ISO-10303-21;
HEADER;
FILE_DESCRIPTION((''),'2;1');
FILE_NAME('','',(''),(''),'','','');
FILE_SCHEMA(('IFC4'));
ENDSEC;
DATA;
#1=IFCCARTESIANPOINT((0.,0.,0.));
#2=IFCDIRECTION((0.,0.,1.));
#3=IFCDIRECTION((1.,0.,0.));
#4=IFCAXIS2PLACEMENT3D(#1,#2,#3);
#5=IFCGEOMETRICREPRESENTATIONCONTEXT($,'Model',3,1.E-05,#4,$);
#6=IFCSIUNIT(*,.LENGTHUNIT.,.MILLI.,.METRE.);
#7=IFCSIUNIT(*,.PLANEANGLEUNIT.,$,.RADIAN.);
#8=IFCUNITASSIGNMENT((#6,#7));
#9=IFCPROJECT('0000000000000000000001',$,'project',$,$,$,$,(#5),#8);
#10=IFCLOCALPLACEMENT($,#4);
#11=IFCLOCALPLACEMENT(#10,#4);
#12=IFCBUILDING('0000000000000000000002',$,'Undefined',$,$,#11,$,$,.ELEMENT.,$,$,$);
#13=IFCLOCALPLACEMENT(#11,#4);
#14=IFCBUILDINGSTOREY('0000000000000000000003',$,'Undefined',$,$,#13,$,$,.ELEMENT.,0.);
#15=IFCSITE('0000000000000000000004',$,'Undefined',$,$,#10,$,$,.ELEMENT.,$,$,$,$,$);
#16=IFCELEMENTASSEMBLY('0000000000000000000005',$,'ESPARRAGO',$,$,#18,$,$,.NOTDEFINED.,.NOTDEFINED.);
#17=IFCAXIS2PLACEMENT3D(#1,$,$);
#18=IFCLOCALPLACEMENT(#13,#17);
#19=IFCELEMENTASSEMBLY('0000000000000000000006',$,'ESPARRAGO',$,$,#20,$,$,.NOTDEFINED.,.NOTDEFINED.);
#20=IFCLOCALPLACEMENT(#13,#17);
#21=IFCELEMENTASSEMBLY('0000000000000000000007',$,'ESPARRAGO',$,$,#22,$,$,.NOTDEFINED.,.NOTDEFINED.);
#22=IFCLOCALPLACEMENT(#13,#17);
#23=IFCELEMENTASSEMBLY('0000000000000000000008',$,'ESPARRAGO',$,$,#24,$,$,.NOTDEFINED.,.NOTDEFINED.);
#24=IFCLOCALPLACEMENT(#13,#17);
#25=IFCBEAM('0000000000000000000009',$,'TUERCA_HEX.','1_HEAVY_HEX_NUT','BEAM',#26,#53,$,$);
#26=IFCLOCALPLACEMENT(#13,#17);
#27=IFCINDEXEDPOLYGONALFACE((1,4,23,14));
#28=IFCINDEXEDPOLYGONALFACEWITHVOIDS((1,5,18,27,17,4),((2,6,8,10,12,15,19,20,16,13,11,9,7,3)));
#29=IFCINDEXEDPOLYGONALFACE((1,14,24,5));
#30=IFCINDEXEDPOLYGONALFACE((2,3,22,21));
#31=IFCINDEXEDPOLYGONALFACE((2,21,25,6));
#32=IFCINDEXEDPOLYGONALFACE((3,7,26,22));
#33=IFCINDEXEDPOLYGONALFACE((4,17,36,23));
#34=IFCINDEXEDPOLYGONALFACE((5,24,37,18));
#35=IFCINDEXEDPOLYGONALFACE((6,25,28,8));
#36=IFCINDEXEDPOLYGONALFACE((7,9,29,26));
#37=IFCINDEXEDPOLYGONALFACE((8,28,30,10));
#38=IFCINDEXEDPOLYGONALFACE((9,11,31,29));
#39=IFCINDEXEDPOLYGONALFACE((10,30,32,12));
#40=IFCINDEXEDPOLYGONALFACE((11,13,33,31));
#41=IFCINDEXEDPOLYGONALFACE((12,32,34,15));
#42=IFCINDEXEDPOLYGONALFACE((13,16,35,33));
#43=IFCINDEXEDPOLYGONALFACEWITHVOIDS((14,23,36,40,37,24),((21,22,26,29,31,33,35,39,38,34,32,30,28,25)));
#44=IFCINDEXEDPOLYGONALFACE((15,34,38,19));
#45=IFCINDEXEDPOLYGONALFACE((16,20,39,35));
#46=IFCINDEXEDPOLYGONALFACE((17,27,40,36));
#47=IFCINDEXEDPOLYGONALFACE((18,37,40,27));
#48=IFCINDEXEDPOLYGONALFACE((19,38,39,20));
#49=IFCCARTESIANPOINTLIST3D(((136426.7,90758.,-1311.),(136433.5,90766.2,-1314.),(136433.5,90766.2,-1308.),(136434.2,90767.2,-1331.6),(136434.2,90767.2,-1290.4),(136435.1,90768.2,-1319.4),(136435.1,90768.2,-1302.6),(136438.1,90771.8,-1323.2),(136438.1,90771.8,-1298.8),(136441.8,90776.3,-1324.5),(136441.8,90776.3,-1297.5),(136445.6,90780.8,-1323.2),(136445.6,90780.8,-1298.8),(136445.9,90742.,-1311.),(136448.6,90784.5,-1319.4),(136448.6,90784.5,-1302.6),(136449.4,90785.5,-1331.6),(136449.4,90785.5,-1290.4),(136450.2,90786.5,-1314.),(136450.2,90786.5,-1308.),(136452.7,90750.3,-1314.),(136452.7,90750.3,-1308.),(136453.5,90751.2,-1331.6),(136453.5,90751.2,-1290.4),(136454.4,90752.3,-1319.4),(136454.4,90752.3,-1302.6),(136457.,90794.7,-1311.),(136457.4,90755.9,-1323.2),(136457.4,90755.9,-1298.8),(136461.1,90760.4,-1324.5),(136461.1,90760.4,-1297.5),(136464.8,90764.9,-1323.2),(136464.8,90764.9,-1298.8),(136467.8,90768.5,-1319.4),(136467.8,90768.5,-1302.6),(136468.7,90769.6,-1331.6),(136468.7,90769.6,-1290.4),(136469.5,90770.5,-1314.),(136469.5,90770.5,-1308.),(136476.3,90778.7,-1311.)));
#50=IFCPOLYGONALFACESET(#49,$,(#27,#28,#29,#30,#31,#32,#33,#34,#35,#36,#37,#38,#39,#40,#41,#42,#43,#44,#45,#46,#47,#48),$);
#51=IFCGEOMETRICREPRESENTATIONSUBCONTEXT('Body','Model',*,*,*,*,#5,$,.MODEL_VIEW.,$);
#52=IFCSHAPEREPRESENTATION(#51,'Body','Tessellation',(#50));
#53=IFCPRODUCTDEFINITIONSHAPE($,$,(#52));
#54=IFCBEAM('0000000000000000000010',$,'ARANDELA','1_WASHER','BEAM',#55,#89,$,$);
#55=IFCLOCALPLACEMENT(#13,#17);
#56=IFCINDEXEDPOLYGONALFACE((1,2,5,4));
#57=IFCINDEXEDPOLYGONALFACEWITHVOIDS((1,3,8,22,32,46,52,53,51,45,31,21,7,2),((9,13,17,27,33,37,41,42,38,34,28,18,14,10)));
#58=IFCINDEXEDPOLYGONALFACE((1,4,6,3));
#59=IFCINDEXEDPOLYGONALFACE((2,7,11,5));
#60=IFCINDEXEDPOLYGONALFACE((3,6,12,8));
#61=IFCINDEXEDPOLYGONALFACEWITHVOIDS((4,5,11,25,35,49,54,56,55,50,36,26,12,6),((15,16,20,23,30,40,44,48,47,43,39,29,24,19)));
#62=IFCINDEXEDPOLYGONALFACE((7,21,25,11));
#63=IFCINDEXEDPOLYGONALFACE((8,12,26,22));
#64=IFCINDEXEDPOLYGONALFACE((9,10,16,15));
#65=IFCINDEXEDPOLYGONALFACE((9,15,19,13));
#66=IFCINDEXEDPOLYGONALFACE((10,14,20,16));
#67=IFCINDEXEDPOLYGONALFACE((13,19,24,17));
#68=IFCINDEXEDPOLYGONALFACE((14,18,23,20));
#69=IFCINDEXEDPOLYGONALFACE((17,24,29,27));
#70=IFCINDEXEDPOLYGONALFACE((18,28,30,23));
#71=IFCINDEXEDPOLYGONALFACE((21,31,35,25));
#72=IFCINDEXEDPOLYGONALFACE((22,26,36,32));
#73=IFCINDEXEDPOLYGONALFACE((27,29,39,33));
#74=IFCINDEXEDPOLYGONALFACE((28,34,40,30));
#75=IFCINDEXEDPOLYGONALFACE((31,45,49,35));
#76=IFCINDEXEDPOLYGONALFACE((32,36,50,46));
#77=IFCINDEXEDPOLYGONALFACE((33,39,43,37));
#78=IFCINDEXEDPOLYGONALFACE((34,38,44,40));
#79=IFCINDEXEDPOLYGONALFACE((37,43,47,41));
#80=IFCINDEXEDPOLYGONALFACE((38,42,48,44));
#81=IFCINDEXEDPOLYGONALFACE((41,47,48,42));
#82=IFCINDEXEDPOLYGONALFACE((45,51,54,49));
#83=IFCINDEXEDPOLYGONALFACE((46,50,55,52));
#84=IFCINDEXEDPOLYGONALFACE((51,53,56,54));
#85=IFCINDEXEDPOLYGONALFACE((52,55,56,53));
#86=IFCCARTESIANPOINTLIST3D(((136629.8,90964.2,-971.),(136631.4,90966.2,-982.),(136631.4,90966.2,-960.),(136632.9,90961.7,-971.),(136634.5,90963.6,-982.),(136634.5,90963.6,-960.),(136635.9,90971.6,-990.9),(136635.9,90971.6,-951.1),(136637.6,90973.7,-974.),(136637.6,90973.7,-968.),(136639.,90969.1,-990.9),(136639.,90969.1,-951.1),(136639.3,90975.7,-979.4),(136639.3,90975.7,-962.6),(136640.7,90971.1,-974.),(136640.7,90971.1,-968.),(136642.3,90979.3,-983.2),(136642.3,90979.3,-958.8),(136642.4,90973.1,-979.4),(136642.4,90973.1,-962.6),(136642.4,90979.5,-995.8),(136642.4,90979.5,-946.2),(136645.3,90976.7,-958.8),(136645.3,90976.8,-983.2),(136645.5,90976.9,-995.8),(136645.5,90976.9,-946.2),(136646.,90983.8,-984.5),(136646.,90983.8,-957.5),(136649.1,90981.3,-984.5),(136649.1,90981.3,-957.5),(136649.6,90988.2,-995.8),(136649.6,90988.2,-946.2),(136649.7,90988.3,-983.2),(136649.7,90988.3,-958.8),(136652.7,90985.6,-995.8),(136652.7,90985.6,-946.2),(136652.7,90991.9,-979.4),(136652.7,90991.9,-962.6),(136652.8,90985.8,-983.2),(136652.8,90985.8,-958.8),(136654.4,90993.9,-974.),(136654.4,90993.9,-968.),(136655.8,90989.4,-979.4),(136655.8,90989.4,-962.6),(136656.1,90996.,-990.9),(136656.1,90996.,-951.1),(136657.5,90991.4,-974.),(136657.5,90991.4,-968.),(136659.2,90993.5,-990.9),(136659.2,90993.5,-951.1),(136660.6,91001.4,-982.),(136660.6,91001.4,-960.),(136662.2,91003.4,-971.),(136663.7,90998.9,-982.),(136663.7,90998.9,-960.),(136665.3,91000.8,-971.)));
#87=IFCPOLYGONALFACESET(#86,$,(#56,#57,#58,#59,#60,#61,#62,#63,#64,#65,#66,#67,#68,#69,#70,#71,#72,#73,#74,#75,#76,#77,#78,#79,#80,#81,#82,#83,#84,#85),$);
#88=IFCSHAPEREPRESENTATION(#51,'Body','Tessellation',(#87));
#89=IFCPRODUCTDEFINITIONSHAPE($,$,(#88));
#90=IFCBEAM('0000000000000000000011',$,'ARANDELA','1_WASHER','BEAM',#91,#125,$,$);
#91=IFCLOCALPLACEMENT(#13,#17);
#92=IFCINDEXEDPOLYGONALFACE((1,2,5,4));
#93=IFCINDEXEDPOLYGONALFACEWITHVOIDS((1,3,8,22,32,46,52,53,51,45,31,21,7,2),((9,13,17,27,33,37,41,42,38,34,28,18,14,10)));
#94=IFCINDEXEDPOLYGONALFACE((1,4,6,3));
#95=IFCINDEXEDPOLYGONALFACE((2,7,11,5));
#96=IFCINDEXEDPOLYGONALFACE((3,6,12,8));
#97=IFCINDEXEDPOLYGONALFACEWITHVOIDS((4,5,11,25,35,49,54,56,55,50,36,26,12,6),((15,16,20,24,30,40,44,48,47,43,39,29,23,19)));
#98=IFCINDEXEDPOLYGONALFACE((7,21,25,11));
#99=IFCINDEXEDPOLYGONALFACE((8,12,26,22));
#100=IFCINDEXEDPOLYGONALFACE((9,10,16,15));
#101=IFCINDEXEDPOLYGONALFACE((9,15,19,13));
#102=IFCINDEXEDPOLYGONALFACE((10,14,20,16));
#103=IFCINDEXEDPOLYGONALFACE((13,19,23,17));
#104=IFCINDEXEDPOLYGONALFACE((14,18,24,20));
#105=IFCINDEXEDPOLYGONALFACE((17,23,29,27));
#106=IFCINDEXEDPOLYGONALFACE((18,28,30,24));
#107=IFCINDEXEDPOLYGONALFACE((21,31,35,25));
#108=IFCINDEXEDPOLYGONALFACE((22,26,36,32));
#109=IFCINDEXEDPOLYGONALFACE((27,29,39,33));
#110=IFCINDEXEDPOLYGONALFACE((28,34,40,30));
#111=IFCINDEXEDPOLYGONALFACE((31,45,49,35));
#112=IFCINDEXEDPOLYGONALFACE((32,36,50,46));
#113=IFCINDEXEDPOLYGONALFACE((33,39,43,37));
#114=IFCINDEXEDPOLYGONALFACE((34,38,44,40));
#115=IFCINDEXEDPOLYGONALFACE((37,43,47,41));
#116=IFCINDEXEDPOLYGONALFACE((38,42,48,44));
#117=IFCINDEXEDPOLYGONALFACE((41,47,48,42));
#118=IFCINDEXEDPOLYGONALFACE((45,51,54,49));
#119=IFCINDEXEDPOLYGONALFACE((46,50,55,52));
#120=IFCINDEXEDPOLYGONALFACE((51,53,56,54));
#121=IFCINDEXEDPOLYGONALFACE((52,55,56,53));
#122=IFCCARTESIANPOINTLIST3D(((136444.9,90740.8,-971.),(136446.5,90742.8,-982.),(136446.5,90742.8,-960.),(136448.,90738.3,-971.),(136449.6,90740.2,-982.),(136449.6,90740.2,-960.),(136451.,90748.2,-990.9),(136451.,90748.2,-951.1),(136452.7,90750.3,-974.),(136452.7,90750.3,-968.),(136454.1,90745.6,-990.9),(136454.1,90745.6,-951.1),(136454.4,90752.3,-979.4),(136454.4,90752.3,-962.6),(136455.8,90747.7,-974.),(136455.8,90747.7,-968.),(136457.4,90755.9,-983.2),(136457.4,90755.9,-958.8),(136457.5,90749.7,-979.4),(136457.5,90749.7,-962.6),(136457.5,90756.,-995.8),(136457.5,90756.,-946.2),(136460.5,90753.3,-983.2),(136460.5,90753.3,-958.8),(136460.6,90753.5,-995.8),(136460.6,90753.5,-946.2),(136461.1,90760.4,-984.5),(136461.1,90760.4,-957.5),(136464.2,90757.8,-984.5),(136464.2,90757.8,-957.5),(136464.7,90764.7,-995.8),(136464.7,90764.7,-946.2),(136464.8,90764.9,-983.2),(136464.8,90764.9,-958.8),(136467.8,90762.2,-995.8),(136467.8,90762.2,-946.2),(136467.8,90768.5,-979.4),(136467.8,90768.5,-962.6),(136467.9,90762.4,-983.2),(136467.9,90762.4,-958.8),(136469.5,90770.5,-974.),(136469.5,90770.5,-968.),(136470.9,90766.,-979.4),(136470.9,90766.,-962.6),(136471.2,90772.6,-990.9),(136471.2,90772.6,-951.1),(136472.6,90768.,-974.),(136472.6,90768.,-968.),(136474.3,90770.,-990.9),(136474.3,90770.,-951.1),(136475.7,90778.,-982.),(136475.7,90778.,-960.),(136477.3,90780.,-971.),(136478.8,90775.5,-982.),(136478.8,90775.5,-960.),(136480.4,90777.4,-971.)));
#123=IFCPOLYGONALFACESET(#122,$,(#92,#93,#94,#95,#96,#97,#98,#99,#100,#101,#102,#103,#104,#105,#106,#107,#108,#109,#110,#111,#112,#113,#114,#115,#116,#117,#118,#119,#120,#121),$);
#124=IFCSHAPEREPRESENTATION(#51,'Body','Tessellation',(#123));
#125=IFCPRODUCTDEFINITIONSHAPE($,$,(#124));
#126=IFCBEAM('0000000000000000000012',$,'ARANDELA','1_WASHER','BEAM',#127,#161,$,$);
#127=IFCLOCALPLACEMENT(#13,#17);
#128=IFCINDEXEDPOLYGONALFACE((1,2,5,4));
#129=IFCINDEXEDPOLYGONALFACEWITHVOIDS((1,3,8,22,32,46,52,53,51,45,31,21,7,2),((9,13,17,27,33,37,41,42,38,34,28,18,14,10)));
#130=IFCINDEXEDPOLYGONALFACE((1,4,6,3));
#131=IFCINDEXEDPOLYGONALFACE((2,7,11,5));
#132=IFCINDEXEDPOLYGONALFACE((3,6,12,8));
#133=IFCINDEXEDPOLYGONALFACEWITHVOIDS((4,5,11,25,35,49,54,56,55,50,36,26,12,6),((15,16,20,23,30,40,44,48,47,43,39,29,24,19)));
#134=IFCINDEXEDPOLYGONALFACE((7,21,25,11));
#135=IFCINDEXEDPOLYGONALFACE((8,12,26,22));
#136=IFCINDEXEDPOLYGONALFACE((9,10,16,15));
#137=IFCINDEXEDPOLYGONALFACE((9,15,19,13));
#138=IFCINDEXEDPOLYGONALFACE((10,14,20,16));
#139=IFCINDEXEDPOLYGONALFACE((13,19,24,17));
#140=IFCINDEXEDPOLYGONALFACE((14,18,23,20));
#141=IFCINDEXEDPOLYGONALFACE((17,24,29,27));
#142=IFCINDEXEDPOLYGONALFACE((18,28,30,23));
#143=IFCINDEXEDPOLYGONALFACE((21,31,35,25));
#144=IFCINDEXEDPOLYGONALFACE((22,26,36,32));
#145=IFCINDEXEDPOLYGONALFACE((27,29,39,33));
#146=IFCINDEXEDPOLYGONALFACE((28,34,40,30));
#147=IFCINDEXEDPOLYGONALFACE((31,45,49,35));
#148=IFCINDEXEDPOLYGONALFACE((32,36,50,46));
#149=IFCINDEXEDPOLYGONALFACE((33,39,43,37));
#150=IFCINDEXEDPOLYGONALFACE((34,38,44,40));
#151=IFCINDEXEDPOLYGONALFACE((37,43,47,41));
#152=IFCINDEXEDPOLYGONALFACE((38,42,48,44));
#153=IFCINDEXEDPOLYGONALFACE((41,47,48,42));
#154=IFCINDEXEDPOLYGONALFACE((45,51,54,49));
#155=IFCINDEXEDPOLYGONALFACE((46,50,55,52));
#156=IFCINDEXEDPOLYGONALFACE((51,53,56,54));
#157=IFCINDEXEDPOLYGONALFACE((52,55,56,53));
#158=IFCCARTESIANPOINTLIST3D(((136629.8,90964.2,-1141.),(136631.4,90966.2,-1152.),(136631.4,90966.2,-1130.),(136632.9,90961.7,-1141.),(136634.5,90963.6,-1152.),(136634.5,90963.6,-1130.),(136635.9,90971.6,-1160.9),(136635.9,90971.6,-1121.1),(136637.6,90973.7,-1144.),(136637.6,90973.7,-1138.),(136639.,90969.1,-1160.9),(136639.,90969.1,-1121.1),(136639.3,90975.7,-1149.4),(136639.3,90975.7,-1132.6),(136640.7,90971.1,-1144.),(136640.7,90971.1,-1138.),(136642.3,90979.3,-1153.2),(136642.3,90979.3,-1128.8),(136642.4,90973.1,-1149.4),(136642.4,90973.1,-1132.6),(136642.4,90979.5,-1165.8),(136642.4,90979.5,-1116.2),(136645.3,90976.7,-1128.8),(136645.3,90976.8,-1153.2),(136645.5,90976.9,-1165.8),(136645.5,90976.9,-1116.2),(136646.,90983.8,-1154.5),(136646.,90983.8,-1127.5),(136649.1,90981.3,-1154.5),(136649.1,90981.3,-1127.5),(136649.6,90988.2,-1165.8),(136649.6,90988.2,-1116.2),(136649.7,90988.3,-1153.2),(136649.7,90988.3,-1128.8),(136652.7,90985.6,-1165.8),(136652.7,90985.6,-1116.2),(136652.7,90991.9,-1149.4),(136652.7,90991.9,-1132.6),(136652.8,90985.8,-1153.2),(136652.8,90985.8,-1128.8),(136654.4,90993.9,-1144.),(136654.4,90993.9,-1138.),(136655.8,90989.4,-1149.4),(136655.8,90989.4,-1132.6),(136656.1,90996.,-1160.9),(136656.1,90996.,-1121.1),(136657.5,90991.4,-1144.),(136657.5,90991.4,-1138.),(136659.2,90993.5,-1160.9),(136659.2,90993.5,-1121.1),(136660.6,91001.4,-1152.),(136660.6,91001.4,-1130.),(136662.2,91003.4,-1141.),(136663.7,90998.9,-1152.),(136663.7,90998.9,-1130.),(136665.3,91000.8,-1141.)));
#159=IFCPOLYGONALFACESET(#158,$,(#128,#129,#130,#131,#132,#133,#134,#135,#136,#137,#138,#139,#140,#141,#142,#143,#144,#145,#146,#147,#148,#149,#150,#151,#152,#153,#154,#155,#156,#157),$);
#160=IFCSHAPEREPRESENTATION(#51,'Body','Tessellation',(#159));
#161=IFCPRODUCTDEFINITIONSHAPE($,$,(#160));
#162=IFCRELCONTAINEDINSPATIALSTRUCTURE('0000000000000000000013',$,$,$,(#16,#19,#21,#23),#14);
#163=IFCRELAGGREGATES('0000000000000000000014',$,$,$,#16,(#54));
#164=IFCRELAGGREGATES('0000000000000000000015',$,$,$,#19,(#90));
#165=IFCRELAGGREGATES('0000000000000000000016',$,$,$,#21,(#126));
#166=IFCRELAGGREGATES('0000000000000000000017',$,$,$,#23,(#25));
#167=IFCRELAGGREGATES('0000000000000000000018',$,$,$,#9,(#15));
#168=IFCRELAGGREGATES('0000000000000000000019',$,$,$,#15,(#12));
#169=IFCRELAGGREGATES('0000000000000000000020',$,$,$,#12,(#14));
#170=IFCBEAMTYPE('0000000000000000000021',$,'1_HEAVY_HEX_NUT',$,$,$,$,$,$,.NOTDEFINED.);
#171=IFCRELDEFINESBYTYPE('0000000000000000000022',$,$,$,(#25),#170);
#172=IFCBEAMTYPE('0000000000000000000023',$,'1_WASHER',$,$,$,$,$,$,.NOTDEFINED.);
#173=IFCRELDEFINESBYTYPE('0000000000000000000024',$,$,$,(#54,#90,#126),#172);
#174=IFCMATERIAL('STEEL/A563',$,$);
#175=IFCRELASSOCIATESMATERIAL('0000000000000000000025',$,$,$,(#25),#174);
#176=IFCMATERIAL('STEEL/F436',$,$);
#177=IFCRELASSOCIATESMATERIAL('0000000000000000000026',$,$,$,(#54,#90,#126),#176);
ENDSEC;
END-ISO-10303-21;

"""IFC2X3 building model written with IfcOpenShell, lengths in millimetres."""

from ifc_helpers import new_model, si_unit, frame, origin_with_axes, place, context, subcontext, project, spatial, polyline, outline, extrude, material, type_object, element, aggregate, save


model = new_model("IFC2X3")

# Units and contexts
model_context = context("Model", 3, precision=1e-05, world=origin_with_axes())
body_context = subcontext(model_context, "Body", "Model", "MODEL_VIEW")
ifc_project = project(units=[si_unit("LENGTHUNIT", "METRE", prefix="MILLI"), si_unit("PLANEANGLEUNIT", "RADIAN")], contexts=[model_context])

# Site, building, storey
site_placement = place(None, origin_with_axes())
site = spatial("IfcSite", under=ifc_project, at=site_placement, Name="Undefined", CompositionType="ELEMENT")
building_placement = place(site_placement, origin_with_axes())
building = spatial("IfcBuilding", under=site, at=building_placement, Name="Undefined", CompositionType="ELEMENT")
storey_placement = place(building_placement, origin_with_axes())
storey = spatial("IfcBuildingStorey", under=building, at=storey_placement, Name="Undefined", CompositionType="ELEMENT", Elevation=0.0)

# Element assemblies, beam
assembly_1_placement = place(storey_placement, origin_with_axes())
assembly_1 = element("IfcElementAssembly", 1, at=assembly_1_placement, inside=storey, Name="ESPARRAGO", AssemblyPlace="NOTDEFINED", PredefinedType="NOTDEFINED")
ifc_material_1 = material(Name="STEEL/A563")
beam_type_1 = type_object("IfcBeamType", Name="1_HEAVY_HEX_NUT", PredefinedType="NOTDEFINED")
assembly_2_placement = place(storey_placement, origin_with_axes())
assembly_2 = element("IfcElementAssembly", 2, at=assembly_2_placement, inside=storey, Name="ESPARRAGO", AssemblyPlace="NOTDEFINED", PredefinedType="NOTDEFINED")
assembly_3_placement = place(storey_placement, origin_with_axes())
assembly_3 = element("IfcElementAssembly", 3, at=assembly_3_placement, inside=storey, Name="ESPARRAGO", AssemblyPlace="NOTDEFINED", PredefinedType="NOTDEFINED")
assembly_4_placement = place(storey_placement, origin_with_axes())
assembly_4 = element("IfcElementAssembly", 4, at=assembly_4_placement, inside=storey, Name="ESPARRAGO", AssemblyPlace="NOTDEFINED", PredefinedType="NOTDEFINED")
beam_1_placement = place(assembly_4_placement, frame((136441.8, 90776.3, -1311.0), z_axis=(0.000011, -0.000009, 1.0), x_axis=(0.770401, -0.63756, -0.000014)))
beam_1 = element("IfcBeam", 5, at=beam_1_placement, type_object=beam_type_1, material=ifc_material_1, Name="TUERCA_HEX.", Description="1_HEAVY_HEX_NUT", ObjectType="BEAM", context=body_context, shape_type="SweptSolid", body=[
    extrude(outline(polyline([(11.9, -20.6), (-11.9, -20.6), (-23.8, 0.0), (-11.9, 20.6), (11.9, 20.6), (23.8, 0.0), (11.9, -20.6)]), holes=[polyline([(-5.9, 12.2), (-10.5, 8.4), (-13.2, 3.0), (-13.2, -3.0), (-10.5, -8.4), (-5.9, -12.2), (0.0, -13.5), (5.9, -12.2), (10.5, -8.4), (13.2, -3.0), (13.2, 3.0), (10.5, 8.4), (5.9, 12.2), (0.0, 13.5), (-5.9, 12.2)])]), frame((25.0, 0.0, 0.0), z_axis=(-1.0, 0.0, 0.0), x_axis=(0.0, -1.0, 0.0)), (0.0, 0.0, 1.0), 25.0),
])

# Beams
ifc_material_2 = material(Name="STEEL/F436")
beam_type_2 = type_object("IfcBeamType", Name="1_WASHER", PredefinedType="NOTDEFINED")
beam_2_placement = place(assembly_1_placement, frame((136646.0, 90983.8, -971.0), z_axis=(0.000066, -0.000055, 1.0), x_axis=(0.770401, -0.63756, -0.000086)))
beam_2 = element("IfcBeam", 6, at=beam_2_placement, type_object=beam_type_2, material=ifc_material_2, Name="ARANDELA", Description="1_WASHER", ObjectType="BEAM", context=body_context, shape_type="SweptSolid", body=[
    extrude(outline(polyline([(-15.8, -19.9), (-22.9, -11.0), (-25.4, 0.0), (-22.9, 11.0), (-15.8, 19.9), (-5.7, 24.8), (5.7, 24.8), (15.8, 19.9), (22.9, 11.0), (25.4, 0.0), (22.9, -11.0), (15.8, -19.9), (5.7, -24.8), (-5.7, -24.8), (-15.8, -19.9)]), holes=[polyline([(-5.9, 12.2), (-10.5, 8.4), (-13.2, 3.0), (-13.2, -3.0), (-10.5, -8.4), (-5.9, -12.2), (0.0, -13.5), (5.9, -12.2), (10.5, -8.4), (13.2, -3.0), (13.2, 3.0), (10.5, 8.4), (5.9, 12.2), (0.0, 13.5), (-5.9, 12.2)])]), frame((4.0, 0.0, 0.0), z_axis=(-1.0, 0.0, 0.0), x_axis=(0.0, -1.0, 0.0)), (0.0, 0.0, 1.0), 4.0),
])
beam_3_placement = place(assembly_2_placement, frame((136461.1, 90760.4, -971.0), z_axis=(0.000066, -0.000055, 1.0), x_axis=(0.770401, -0.63756, -0.000086)))
beam_3 = element("IfcBeam", 7, at=beam_3_placement, type_object=beam_type_2, material=ifc_material_2, Name="ARANDELA", Description="1_WASHER", ObjectType="BEAM", context=body_context, shape_type="SweptSolid", body=[
    extrude(outline(polyline([(-15.8, -19.9), (-22.9, -11.0), (-25.4, 0.0), (-22.9, 11.0), (-15.8, 19.9), (-5.7, 24.8), (5.7, 24.8), (15.8, 19.9), (22.9, 11.0), (25.4, 0.0), (22.9, -11.0), (15.8, -19.9), (5.7, -24.8), (-5.7, -24.8), (-15.8, -19.9)]), holes=[polyline([(-5.9, 12.2), (-10.5, 8.4), (-13.2, 3.0), (-13.2, -3.0), (-10.5, -8.4), (-5.9, -12.2), (0.0, -13.5), (5.9, -12.2), (10.5, -8.4), (13.2, -3.0), (13.2, 3.0), (10.5, 8.4), (5.9, 12.2), (0.0, 13.5), (-5.9, 12.2)])]), frame((4.0, 0.0, 0.0), z_axis=(-1.0, 0.0, 0.0), x_axis=(0.0, -1.0, 0.0)), (0.0, 0.0, 1.0), 4.0),
])
beam_4_placement = place(assembly_3_placement, frame((136646.0, 90983.8, -1141.0), z_axis=(0.000066, -0.000055, 1.0), x_axis=(0.770401, -0.63756, -0.000086)))
beam_4 = element("IfcBeam", 8, at=beam_4_placement, type_object=beam_type_2, material=ifc_material_2, Name="ARANDELA", Description="1_WASHER", ObjectType="BEAM", context=body_context, shape_type="SweptSolid", body=[
    extrude(outline(polyline([(-15.8, -19.9), (-22.9, -11.0), (-25.4, 0.0), (-22.9, 11.0), (-15.8, 19.9), (-5.7, 24.8), (5.7, 24.8), (15.8, 19.9), (22.9, 11.0), (25.4, 0.0), (22.9, -11.0), (15.8, -19.9), (5.7, -24.8), (-5.7, -24.8), (-15.8, -19.9)]), holes=[polyline([(-5.9, 12.2), (-10.5, 8.4), (-13.2, 3.0), (-13.2, -3.0), (-10.5, -8.4), (-5.9, -12.2), (0.0, -13.5), (5.9, -12.2), (10.5, -8.4), (13.2, -3.0), (13.2, 3.0), (10.5, 8.4), (5.9, 12.2), (0.0, 13.5), (-5.9, 12.2)])]), frame((4.0, 0.0, 0.0), z_axis=(-1.0, 0.0, 0.0), x_axis=(0.0, -1.0, 0.0)), (0.0, 0.0, 1.0), 4.0),
])
aggregate(assembly_1, [beam_2])
aggregate(assembly_2, [beam_3])
aggregate(assembly_3, [beam_4])
aggregate(assembly_4, [beam_1])

save(model, "model.ifc")
